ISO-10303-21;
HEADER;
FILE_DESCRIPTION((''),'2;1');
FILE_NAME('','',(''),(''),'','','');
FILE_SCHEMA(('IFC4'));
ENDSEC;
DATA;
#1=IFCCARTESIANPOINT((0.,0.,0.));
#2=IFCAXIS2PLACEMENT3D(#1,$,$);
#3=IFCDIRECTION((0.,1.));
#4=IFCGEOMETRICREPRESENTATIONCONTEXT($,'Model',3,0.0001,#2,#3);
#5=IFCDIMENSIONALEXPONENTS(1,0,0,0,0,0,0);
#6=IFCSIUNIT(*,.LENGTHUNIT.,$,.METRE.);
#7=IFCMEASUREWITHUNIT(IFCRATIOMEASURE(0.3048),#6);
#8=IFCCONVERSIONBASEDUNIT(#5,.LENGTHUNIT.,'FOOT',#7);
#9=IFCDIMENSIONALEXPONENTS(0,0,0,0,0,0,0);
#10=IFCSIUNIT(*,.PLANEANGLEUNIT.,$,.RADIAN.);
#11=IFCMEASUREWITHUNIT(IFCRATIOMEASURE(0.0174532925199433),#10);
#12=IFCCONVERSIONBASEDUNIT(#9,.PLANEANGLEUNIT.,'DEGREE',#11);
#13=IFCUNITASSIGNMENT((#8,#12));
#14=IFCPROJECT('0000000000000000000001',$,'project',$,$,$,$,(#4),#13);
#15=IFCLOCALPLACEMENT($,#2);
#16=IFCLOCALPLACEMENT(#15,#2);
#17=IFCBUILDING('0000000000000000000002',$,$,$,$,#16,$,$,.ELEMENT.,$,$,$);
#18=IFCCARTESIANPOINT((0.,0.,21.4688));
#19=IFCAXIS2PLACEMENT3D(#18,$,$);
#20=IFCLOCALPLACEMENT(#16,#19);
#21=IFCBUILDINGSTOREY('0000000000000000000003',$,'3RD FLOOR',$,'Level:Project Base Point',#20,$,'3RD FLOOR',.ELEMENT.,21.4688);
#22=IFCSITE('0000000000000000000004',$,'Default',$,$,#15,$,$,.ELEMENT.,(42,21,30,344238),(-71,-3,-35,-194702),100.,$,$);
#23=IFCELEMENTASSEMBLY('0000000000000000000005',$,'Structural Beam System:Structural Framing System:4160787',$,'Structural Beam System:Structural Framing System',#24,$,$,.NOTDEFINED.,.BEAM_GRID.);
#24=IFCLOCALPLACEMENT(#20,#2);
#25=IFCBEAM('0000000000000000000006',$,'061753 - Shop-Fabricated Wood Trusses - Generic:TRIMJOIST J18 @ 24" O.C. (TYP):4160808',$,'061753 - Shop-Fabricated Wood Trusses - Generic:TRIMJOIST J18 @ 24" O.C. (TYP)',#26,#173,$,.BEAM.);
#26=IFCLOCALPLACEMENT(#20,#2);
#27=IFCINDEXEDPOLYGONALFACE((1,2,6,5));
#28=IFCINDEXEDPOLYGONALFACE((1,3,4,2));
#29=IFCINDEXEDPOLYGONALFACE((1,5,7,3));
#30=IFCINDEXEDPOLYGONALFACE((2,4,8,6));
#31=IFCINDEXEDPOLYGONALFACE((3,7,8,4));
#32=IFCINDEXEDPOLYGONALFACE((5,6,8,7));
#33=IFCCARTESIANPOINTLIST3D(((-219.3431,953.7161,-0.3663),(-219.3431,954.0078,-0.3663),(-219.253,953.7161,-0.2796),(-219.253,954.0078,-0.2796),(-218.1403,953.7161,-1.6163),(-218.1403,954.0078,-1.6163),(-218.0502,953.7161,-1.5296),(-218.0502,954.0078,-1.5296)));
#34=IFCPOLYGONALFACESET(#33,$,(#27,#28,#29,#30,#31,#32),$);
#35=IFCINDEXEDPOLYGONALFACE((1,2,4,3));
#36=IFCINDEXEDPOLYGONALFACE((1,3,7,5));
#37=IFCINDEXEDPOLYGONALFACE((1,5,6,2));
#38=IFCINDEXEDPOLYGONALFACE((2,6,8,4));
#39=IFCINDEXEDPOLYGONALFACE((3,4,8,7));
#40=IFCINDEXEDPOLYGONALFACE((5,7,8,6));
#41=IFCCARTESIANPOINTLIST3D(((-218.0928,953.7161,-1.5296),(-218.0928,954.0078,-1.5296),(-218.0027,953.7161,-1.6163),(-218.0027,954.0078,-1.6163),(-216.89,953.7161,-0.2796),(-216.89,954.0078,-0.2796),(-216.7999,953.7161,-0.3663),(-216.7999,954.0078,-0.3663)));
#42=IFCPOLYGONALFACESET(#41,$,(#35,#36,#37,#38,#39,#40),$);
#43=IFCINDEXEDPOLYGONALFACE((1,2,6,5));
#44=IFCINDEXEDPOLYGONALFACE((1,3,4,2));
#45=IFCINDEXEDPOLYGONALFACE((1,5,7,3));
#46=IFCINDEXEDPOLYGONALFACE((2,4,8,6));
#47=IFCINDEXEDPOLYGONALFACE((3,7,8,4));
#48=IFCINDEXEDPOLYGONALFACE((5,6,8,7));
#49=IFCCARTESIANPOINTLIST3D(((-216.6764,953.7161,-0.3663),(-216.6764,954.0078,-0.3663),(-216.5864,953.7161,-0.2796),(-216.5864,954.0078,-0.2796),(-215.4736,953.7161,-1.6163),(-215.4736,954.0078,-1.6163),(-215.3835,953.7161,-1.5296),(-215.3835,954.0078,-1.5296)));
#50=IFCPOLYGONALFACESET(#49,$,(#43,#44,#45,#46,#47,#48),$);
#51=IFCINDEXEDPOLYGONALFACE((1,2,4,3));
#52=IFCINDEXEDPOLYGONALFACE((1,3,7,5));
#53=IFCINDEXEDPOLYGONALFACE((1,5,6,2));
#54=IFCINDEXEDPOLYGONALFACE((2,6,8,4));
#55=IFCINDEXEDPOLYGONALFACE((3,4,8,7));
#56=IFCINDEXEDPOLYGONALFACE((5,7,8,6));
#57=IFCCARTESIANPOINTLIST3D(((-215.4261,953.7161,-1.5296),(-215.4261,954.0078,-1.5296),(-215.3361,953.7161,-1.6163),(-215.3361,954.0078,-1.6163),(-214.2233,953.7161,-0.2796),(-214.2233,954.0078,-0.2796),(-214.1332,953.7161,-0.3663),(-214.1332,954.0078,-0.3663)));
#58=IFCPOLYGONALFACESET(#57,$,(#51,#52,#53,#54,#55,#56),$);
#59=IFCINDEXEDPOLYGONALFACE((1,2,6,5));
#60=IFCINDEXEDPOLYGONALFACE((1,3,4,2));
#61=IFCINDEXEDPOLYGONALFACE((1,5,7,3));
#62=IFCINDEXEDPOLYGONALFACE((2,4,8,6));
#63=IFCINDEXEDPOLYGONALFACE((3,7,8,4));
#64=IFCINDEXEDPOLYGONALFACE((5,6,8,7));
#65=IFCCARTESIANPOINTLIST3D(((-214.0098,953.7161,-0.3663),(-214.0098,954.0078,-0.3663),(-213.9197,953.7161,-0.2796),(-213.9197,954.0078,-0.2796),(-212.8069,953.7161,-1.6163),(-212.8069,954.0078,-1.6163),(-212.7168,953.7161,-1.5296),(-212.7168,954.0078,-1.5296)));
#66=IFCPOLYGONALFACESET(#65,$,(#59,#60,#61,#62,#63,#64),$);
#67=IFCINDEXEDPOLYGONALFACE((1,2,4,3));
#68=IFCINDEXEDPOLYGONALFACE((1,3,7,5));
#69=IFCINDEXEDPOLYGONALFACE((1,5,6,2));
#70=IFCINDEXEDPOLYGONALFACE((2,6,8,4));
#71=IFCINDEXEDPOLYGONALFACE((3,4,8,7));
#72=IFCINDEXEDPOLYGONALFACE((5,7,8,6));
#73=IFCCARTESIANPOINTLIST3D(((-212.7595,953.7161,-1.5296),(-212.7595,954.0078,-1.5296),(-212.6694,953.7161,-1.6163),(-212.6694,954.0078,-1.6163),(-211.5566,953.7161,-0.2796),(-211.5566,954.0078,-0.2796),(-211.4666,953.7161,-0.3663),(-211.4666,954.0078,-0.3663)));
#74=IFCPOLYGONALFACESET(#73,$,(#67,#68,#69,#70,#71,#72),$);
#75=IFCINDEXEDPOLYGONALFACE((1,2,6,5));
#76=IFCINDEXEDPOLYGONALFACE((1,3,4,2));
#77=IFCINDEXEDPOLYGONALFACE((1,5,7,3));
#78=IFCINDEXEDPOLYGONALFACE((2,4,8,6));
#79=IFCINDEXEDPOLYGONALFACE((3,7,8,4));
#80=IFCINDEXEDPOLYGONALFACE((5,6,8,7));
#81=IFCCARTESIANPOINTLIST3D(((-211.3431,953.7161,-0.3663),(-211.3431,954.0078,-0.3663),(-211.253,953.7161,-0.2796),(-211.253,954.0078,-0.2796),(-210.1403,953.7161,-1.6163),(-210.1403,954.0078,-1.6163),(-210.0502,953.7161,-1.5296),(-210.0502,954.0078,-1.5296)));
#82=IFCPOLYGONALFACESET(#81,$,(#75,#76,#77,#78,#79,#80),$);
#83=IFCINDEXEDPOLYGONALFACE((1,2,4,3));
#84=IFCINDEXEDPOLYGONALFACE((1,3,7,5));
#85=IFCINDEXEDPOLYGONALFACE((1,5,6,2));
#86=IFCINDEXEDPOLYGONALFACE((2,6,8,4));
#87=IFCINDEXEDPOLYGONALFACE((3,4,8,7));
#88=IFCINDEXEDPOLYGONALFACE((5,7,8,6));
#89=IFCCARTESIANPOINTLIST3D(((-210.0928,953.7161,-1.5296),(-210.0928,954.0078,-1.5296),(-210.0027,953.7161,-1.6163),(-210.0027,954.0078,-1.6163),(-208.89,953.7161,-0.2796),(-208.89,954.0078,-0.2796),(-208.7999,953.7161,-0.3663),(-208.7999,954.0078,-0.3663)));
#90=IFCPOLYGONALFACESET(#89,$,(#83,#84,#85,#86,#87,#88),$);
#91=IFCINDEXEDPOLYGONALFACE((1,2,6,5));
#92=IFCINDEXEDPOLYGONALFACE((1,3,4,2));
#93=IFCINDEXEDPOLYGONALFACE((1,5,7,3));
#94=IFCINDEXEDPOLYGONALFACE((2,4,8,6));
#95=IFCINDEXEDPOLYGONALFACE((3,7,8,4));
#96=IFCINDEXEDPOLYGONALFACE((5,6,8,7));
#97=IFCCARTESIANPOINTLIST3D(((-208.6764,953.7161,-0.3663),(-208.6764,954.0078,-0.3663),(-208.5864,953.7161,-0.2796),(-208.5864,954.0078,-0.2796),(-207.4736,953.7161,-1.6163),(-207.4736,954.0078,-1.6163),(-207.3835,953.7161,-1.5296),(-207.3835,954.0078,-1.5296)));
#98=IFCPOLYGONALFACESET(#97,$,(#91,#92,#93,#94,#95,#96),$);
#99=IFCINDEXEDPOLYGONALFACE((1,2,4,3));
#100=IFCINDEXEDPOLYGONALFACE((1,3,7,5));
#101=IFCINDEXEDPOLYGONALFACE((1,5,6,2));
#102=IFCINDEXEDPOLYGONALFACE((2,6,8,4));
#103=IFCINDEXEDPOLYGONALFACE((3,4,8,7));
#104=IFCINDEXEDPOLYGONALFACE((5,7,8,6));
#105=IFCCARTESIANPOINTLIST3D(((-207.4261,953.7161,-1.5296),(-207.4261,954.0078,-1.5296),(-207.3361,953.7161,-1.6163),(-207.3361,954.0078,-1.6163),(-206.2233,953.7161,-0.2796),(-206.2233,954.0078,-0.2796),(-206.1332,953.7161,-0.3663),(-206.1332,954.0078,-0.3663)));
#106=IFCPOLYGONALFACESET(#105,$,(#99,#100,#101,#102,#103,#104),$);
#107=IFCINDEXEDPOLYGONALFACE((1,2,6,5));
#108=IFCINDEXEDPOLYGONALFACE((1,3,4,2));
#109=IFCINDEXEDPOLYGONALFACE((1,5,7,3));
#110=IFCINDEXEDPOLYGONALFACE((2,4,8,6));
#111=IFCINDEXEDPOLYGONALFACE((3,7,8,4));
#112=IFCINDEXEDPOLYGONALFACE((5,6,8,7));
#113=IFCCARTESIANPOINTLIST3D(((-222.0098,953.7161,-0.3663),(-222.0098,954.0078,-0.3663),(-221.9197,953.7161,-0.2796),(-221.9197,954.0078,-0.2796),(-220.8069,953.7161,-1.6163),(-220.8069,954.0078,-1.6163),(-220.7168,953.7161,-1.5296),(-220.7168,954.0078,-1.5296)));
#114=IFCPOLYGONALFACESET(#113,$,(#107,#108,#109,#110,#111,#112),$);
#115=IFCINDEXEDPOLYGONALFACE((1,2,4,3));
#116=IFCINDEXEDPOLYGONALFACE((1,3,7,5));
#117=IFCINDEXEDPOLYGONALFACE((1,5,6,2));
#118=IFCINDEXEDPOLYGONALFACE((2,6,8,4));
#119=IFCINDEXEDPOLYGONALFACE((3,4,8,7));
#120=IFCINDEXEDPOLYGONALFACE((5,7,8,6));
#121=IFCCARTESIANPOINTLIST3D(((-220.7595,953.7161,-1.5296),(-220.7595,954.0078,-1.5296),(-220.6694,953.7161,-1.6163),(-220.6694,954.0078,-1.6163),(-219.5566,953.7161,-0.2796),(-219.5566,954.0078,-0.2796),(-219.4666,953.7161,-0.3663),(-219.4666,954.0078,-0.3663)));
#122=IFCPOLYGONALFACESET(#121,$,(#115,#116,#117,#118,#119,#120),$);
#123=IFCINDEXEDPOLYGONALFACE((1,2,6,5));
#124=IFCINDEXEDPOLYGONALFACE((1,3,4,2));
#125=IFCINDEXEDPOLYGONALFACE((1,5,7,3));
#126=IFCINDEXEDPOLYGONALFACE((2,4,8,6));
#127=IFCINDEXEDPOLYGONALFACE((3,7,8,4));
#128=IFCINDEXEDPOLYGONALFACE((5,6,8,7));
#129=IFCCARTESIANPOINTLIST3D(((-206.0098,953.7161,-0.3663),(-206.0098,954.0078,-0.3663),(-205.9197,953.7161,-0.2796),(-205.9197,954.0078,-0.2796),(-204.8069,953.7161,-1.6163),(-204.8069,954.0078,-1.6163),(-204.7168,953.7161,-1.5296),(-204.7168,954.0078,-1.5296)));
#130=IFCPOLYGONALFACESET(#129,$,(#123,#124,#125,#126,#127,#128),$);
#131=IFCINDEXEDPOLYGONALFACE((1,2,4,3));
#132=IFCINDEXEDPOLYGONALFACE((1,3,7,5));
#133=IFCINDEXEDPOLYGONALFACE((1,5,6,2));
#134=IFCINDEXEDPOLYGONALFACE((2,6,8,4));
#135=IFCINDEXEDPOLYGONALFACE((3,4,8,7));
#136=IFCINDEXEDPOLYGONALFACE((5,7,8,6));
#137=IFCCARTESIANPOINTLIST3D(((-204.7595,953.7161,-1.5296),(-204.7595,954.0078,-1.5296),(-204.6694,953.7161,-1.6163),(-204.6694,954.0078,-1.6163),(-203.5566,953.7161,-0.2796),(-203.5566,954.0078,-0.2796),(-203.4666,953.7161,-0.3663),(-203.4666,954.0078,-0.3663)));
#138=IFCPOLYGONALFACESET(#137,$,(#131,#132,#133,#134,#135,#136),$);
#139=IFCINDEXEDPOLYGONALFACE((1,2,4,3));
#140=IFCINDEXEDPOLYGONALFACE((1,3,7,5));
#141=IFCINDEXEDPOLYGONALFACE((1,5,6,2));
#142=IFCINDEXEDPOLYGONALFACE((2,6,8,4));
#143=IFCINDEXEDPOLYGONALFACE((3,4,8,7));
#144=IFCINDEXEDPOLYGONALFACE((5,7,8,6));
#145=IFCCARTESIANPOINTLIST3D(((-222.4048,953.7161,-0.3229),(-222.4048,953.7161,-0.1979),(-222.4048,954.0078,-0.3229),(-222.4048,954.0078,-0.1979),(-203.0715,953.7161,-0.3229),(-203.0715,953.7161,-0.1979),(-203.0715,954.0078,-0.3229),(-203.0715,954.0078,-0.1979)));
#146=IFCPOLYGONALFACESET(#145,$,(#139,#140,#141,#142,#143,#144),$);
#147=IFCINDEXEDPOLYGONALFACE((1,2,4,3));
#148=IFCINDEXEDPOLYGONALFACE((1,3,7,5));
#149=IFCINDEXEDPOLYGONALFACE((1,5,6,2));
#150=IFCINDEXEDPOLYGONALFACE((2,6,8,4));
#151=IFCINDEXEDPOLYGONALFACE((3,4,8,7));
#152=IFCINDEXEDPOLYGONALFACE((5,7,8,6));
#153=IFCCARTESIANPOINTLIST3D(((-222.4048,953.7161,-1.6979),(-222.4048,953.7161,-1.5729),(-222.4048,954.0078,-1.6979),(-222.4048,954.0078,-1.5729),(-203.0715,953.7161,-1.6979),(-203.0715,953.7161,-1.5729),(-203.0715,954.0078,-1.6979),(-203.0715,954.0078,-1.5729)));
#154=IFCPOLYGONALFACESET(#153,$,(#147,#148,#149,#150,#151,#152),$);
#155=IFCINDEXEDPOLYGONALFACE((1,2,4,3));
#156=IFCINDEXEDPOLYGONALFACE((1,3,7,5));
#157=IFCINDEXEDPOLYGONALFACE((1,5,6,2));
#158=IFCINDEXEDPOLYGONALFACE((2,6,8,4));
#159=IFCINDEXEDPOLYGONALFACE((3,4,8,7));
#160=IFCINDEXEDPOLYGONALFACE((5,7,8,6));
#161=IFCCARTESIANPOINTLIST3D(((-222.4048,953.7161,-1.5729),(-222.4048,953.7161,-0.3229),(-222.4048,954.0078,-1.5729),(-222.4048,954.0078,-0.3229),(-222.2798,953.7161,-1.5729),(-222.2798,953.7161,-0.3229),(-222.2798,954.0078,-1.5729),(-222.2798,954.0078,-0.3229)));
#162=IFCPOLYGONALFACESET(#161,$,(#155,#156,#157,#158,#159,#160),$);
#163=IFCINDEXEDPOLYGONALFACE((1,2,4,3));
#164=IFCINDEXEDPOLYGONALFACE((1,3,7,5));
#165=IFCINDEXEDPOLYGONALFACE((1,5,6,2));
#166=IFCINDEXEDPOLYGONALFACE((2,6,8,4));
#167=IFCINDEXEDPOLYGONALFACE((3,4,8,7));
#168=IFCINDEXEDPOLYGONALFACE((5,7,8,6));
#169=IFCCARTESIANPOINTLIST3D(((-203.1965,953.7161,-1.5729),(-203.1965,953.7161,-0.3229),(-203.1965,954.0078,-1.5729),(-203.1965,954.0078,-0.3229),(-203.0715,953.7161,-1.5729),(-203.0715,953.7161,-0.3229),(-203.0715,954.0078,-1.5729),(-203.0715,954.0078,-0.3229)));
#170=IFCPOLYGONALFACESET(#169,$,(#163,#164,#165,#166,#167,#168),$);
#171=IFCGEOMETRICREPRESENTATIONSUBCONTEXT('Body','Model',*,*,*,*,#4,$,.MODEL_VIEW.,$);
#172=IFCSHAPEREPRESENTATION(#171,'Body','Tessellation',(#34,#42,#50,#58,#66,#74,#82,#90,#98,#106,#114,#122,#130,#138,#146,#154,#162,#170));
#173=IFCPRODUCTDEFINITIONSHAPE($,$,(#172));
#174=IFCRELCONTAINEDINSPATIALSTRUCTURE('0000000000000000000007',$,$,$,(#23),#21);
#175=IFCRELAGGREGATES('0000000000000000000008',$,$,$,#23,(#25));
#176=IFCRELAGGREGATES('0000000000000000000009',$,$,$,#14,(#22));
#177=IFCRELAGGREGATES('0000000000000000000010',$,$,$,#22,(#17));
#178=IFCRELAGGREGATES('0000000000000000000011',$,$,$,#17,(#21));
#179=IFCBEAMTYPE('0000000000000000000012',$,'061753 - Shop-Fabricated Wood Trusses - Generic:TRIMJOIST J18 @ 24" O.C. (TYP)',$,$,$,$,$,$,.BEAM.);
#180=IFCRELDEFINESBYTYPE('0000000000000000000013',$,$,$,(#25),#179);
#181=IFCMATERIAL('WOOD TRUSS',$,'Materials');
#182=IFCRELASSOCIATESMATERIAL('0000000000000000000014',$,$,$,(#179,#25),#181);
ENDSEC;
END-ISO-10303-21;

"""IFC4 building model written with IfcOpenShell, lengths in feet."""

from ifc_helpers import new_model, entity, si_unit, converted_unit, direction, frame, frame_2d, origin, origin_2d_with_axis, place, context, subcontext, project, spatial, rectangle, extrude, source, transform, mapped, material, material_profile, profile_set, profile_usage, type_object, type_shapes, element, aggregate, save


model = new_model("IFC4")

# Units and contexts
model_context = context("Model", 3, precision=0.0001, world=origin(), true_north=direction((0.0, 1.0)))
body_context = subcontext(model_context, "Body", "Model", "MODEL_VIEW")
ifc_project = project(units=[converted_unit("LENGTHUNIT", "FOOT", entity("IfcRatioMeasure", 0.3048), si_unit("LENGTHUNIT", "METRE"), dimensions=[1, 0, 0, 0, 0, 0, 0]), converted_unit("PLANEANGLEUNIT", "DEGREE", entity("IfcRatioMeasure", 0.0174532925199433), si_unit("PLANEANGLEUNIT", "RADIAN"), dimensions=[0, 0, 0, 0, 0, 0, 0])], contexts=[model_context])

# Site, building, storey
site_placement = place(None, origin())
site = spatial("IfcSite", under=ifc_project, at=site_placement, Name="Default", CompositionType="ELEMENT", RefLatitude=(42, 21, 30, 344238), RefLongitude=(-71, -3, -35, -194702), RefElevation=100.0)
building_placement = place(site_placement, origin())
building = spatial("IfcBuilding", under=site, at=building_placement, CompositionType="ELEMENT")
storey_placement = place(building_placement, frame((0.0, 0.0, 21.4688)))
storey = spatial("IfcBuildingStorey", under=building, at=storey_placement, Name="3RD FLOOR", ObjectType="Level:Project Base Point", LongName="3RD FLOOR", CompositionType="ELEMENT", Elevation=21.4688)

# Element assembly, beam
ifc_material_1 = material(Name="WOOD TRUSS", Category="Materials")
ifc_material_profile_1 = material_profile(ifc_material_1, rectangle(XDim=1.7347, YDim=0.125, at=frame_2d((0.0, 0.0), x_axis=(1.0, 0.0))), Name="TRIMJOIST J18 @ 24\" O.C. (TYP)")
ifc_material_profile_2 = material_profile(ifc_material_1, rectangle(XDim=1.7347, YDim=0.125, at=frame_2d((0.0, 0.0), x_axis=(1.0, 0.0))), Name="TRIMJOIST J18 @ 24\" O.C. (TYP)")
ifc_material_profile_3 = material_profile(ifc_material_1, rectangle(XDim=1.7347, YDim=0.125, at=frame_2d((0.0, 0.0), x_axis=(1.0, 0.0))), Name="TRIMJOIST J18 @ 24\" O.C. (TYP)")
ifc_material_profile_4 = material_profile(ifc_material_1, rectangle(XDim=1.7347, YDim=0.125, at=frame_2d((0.0, 0.0), x_axis=(1.0, 0.0))), Name="TRIMJOIST J18 @ 24\" O.C. (TYP)")
ifc_material_profile_5 = material_profile(ifc_material_1, rectangle(XDim=1.7347, YDim=0.125, at=frame_2d((0.0, 0.0), x_axis=(1.0, 0.0))), Name="TRIMJOIST J18 @ 24\" O.C. (TYP)")
ifc_material_profile_6 = material_profile(ifc_material_1, rectangle(XDim=1.7347, YDim=0.125, at=frame_2d((0.0, 0.0), x_axis=(1.0, 0.0))), Name="TRIMJOIST J18 @ 24\" O.C. (TYP)")
ifc_material_profile_7 = material_profile(ifc_material_1, rectangle(XDim=1.7347, YDim=0.125, at=frame_2d((0.0, 0.0), x_axis=(1.0, 0.0))), Name="TRIMJOIST J18 @ 24\" O.C. (TYP)")
ifc_material_profile_8 = material_profile(ifc_material_1, rectangle(XDim=1.7347, YDim=0.125, at=frame_2d((0.0, 0.0), x_axis=(1.0, 0.0))), Name="TRIMJOIST J18 @ 24\" O.C. (TYP)")
ifc_material_profile_9 = material_profile(ifc_material_1, rectangle(XDim=1.7347, YDim=0.125, at=frame_2d((0.0, 0.0), x_axis=(1.0, 0.0))), Name="TRIMJOIST J18 @ 24\" O.C. (TYP)")
ifc_material_profile_10 = material_profile(ifc_material_1, rectangle(XDim=1.7347, YDim=0.125, at=origin_2d_with_axis()), Name="TRIMJOIST J18 @ 24\" O.C. (TYP)")
ifc_material_profile_11 = material_profile(ifc_material_1, rectangle(XDim=0.125, YDim=0.2917, at=origin_2d_with_axis()), Name="TRIMJOIST J18 @ 24\" O.C. (TYP)")
ifc_material_profile_12 = material_profile(ifc_material_1, rectangle(XDim=0.125, YDim=0.2917, at=origin_2d_with_axis()), Name="TRIMJOIST J18 @ 24\" O.C. (TYP)")
ifc_material_profile_13 = material_profile(ifc_material_1, rectangle(XDim=1.25, YDim=0.2917, at=origin_2d_with_axis()), Name="TRIMJOIST J18 @ 24\" O.C. (TYP)")
ifc_material_profile_14 = material_profile(ifc_material_1, rectangle(XDim=1.25, YDim=0.2917, at=origin_2d_with_axis()), Name="TRIMJOIST J18 @ 24\" O.C. (TYP)")
ifc_profile_set_1 = profile_set([ifc_material_profile_1, ifc_material_profile_2, ifc_material_profile_3, ifc_material_profile_4, ifc_material_profile_5, ifc_material_profile_6, ifc_material_profile_7, ifc_material_profile_8, ifc_material_profile_9, ifc_material_profile_10, ifc_material_profile_11, ifc_material_profile_12, ifc_material_profile_13, ifc_material_profile_14], Name="TRIMJOIST J18 @ 24\" O.C. (TYP)")
beam_type_1 = type_object("IfcBeamType", Name="061753 - Shop-Fabricated Wood Trusses - Generic:TRIMJOIST J18 @ 24\" O.C. (TYP)", PredefinedType="BEAM", material=ifc_profile_set_1)
shared_shape_1 = source(origin(), body_context, "Body", "SweptSolid", [
    extrude(rectangle(XDim=1.7347, YDim=0.125, at=frame_2d((0.0, 0.0), x_axis=(1.0, 0.0))), frame((5.9585, -0.1458, 0.0), z_axis=(0.0, 1.0, 0.0), x_axis=(0.693383, 0.0, 0.720569)), (0.0, 0.0, 1.0), 0.2917),
    extrude(rectangle(XDim=1.7347, YDim=0.125, at=origin_2d_with_axis()), frame((4.7082, -0.1458, 0.0), z_axis=(0.0, 1.0, 0.0), x_axis=(0.693383, 0.0, -0.720569)), (0.0, 0.0, 1.0), 0.2917),
    extrude(rectangle(XDim=1.7347, YDim=0.125, at=frame_2d((0.0, 0.0), x_axis=(1.0, 0.0))), frame((3.2918, -0.1458, 0.0), z_axis=(0.0, 1.0, 0.0), x_axis=(0.693383, 0.0, 0.720569)), (0.0, 0.0, 1.0), 0.2917),
    extrude(rectangle(XDim=1.7347, YDim=0.125, at=frame_2d((0.0, 0.0), x_axis=(1.0, 0.0))), frame((2.0415, -0.1458, 0.0), z_axis=(0.0, 1.0, 0.0), x_axis=(0.693383, 0.0, -0.720569)), (0.0, 0.0, 1.0), 0.2917),
    extrude(rectangle(XDim=1.7347, YDim=0.125, at=frame_2d((0.0, 0.0), x_axis=(1.0, 0.0))), frame((0.6251, -0.1458, 0.0), z_axis=(0.0, 1.0, 0.0), x_axis=(0.693383, 0.0, 0.720569)), (0.0, 0.0, 1.0), 0.2917),
    extrude(rectangle(XDim=1.7347, YDim=0.125, at=frame_2d((0.0, 0.0), x_axis=(1.0, 0.0))), frame((-0.6251, -0.1458, 0.0), z_axis=(0.0, 1.0, 0.0), x_axis=(0.693383, 0.0, -0.720569)), (0.0, 0.0, 1.0), 0.2917),
    extrude(rectangle(XDim=1.7347, YDim=0.125, at=frame_2d((0.0, 0.0), x_axis=(1.0, 0.0))), frame((-2.0415, -0.1458, 0.0), z_axis=(0.0, 1.0, 0.0), x_axis=(0.693383, 0.0, 0.720569)), (0.0, 0.0, 1.0), 0.2917),
    extrude(rectangle(XDim=1.7347, YDim=0.125, at=origin_2d_with_axis()), frame((-3.2918, -0.1458, 0.0), z_axis=(0.0, 1.0, 0.0), x_axis=(0.693383, 0.0, -0.720569)), (0.0, 0.0, 1.0), 0.2917),
    extrude(rectangle(XDim=1.7347, YDim=0.125, at=frame_2d((0.0, 0.0), x_axis=(1.0, 0.0))), frame((-4.7082, -0.1458, 0.0), z_axis=(0.0, 1.0, 0.0), x_axis=(0.693383, 0.0, 0.720569)), (0.0, 0.0, 1.0), 0.2917),
    extrude(rectangle(XDim=1.7347, YDim=0.125, at=frame_2d((0.0, 0.0), x_axis=(1.0, 0.0))), frame((-5.9585, -0.1458, 0.0), z_axis=(0.0, 1.0, 0.0), x_axis=(0.693383, 0.0, -0.720569)), (0.0, 0.0, 1.0), 0.2917),
    extrude(rectangle(XDim=1.7347, YDim=0.125, at=frame_2d((0.0, 0.0), x_axis=(1.0, 0.0))), frame((8.6251, -0.1458, 0.0), z_axis=(0.0, 1.0, 0.0), x_axis=(0.693383, 0.0, 0.720569)), (0.0, 0.0, 1.0), 0.2917),
    extrude(rectangle(XDim=1.7347, YDim=0.125, at=origin_2d_with_axis()), frame((7.3749, -0.1458, 0.0), z_axis=(0.0, 1.0, 0.0), x_axis=(0.693383, 0.0, -0.720569)), (0.0, 0.0, 1.0), 0.2917),
    extrude(rectangle(XDim=1.7347, YDim=0.125, at=frame_2d((0.0, 0.0), x_axis=(1.0, 0.0))), frame((-7.3749, -0.1458, 0.0), z_axis=(0.0, 1.0, 0.0), x_axis=(0.693383, 0.0, 0.720569)), (0.0, 0.0, 1.0), 0.2917),
    extrude(rectangle(XDim=1.7347, YDim=0.125, at=origin_2d_with_axis()), frame((-8.6251, -0.1458, 0.0), z_axis=(0.0, 1.0, 0.0), x_axis=(0.693383, 0.0, -0.720569)), (0.0, 0.0, 1.0), 0.2917),
    extrude(rectangle(XDim=0.125, YDim=0.2917, at=origin_2d_with_axis()), frame((-9.6667, 0.0, 0.6875), z_axis=(1.0, 0.0, 0.0), x_axis=(0.0, 0.0, -1.0)), (0.0, 0.0, 1.0), 19.3333),
    extrude(rectangle(XDim=0.125, YDim=0.2917, at=origin_2d_with_axis()), frame((-9.6667, 0.0, -0.6875), z_axis=(1.0, 0.0, 0.0), x_axis=(0.0, 0.0, -1.0)), (0.0, 0.0, 1.0), 19.3333),
    extrude(rectangle(XDim=1.25, YDim=0.2917, at=origin_2d_with_axis()), frame((9.5417, 0.0, 0.0), z_axis=(1.0, 0.0, 0.0), x_axis=(0.0, 0.0, -1.0)), (0.0, 0.0, 1.0), 0.125),
    extrude(rectangle(XDim=1.25, YDim=0.2917, at=origin_2d_with_axis()), frame((-9.6667, 0.0, 0.0), z_axis=(1.0, 0.0, 0.0), x_axis=(0.0, 0.0, -1.0)), (0.0, 0.0, 1.0), 0.125),
])
type_shapes(beam_type_1, [shared_shape_1])
assembly_1_placement = place(storey_placement, origin())
assembly_1 = element("IfcElementAssembly", 1, at=assembly_1_placement, inside=storey, Name="Structural Beam System:Structural Framing System:4160787", ObjectType="Structural Beam System:Structural Framing System", AssemblyPlace="NOTDEFINED", PredefinedType="BEAM_GRID")
ifc_profile_usage_1 = profile_usage(ifc_profile_set_1, cardinal=8)
beam_1_placement = place(assembly_1_placement, frame((-212.7382, 953.8619, -0.9479), z_axis=(0.0, 0.0, 1.0), x_axis=(-1.0, 0.0, 0.0)))
beam_1 = element("IfcBeam", 2, at=beam_1_placement, type_object=beam_type_1, material=ifc_profile_usage_1, Name="061753 - Shop-Fabricated Wood Trusses - Generic:TRIMJOIST J18 @ 24\" O.C. (TYP):4160808", ObjectType="061753 - Shop-Fabricated Wood Trusses - Generic:TRIMJOIST J18 @ 24\" O.C. (TYP)", PredefinedType="BEAM", context=body_context, shape_type="MappedRepresentation", body=[
    mapped(shared_shape_1, transform((0.0, 0.0, 0.0), scale=1.0)),
])
aggregate(assembly_1, [beam_1])

save(model, "model.ifc")
